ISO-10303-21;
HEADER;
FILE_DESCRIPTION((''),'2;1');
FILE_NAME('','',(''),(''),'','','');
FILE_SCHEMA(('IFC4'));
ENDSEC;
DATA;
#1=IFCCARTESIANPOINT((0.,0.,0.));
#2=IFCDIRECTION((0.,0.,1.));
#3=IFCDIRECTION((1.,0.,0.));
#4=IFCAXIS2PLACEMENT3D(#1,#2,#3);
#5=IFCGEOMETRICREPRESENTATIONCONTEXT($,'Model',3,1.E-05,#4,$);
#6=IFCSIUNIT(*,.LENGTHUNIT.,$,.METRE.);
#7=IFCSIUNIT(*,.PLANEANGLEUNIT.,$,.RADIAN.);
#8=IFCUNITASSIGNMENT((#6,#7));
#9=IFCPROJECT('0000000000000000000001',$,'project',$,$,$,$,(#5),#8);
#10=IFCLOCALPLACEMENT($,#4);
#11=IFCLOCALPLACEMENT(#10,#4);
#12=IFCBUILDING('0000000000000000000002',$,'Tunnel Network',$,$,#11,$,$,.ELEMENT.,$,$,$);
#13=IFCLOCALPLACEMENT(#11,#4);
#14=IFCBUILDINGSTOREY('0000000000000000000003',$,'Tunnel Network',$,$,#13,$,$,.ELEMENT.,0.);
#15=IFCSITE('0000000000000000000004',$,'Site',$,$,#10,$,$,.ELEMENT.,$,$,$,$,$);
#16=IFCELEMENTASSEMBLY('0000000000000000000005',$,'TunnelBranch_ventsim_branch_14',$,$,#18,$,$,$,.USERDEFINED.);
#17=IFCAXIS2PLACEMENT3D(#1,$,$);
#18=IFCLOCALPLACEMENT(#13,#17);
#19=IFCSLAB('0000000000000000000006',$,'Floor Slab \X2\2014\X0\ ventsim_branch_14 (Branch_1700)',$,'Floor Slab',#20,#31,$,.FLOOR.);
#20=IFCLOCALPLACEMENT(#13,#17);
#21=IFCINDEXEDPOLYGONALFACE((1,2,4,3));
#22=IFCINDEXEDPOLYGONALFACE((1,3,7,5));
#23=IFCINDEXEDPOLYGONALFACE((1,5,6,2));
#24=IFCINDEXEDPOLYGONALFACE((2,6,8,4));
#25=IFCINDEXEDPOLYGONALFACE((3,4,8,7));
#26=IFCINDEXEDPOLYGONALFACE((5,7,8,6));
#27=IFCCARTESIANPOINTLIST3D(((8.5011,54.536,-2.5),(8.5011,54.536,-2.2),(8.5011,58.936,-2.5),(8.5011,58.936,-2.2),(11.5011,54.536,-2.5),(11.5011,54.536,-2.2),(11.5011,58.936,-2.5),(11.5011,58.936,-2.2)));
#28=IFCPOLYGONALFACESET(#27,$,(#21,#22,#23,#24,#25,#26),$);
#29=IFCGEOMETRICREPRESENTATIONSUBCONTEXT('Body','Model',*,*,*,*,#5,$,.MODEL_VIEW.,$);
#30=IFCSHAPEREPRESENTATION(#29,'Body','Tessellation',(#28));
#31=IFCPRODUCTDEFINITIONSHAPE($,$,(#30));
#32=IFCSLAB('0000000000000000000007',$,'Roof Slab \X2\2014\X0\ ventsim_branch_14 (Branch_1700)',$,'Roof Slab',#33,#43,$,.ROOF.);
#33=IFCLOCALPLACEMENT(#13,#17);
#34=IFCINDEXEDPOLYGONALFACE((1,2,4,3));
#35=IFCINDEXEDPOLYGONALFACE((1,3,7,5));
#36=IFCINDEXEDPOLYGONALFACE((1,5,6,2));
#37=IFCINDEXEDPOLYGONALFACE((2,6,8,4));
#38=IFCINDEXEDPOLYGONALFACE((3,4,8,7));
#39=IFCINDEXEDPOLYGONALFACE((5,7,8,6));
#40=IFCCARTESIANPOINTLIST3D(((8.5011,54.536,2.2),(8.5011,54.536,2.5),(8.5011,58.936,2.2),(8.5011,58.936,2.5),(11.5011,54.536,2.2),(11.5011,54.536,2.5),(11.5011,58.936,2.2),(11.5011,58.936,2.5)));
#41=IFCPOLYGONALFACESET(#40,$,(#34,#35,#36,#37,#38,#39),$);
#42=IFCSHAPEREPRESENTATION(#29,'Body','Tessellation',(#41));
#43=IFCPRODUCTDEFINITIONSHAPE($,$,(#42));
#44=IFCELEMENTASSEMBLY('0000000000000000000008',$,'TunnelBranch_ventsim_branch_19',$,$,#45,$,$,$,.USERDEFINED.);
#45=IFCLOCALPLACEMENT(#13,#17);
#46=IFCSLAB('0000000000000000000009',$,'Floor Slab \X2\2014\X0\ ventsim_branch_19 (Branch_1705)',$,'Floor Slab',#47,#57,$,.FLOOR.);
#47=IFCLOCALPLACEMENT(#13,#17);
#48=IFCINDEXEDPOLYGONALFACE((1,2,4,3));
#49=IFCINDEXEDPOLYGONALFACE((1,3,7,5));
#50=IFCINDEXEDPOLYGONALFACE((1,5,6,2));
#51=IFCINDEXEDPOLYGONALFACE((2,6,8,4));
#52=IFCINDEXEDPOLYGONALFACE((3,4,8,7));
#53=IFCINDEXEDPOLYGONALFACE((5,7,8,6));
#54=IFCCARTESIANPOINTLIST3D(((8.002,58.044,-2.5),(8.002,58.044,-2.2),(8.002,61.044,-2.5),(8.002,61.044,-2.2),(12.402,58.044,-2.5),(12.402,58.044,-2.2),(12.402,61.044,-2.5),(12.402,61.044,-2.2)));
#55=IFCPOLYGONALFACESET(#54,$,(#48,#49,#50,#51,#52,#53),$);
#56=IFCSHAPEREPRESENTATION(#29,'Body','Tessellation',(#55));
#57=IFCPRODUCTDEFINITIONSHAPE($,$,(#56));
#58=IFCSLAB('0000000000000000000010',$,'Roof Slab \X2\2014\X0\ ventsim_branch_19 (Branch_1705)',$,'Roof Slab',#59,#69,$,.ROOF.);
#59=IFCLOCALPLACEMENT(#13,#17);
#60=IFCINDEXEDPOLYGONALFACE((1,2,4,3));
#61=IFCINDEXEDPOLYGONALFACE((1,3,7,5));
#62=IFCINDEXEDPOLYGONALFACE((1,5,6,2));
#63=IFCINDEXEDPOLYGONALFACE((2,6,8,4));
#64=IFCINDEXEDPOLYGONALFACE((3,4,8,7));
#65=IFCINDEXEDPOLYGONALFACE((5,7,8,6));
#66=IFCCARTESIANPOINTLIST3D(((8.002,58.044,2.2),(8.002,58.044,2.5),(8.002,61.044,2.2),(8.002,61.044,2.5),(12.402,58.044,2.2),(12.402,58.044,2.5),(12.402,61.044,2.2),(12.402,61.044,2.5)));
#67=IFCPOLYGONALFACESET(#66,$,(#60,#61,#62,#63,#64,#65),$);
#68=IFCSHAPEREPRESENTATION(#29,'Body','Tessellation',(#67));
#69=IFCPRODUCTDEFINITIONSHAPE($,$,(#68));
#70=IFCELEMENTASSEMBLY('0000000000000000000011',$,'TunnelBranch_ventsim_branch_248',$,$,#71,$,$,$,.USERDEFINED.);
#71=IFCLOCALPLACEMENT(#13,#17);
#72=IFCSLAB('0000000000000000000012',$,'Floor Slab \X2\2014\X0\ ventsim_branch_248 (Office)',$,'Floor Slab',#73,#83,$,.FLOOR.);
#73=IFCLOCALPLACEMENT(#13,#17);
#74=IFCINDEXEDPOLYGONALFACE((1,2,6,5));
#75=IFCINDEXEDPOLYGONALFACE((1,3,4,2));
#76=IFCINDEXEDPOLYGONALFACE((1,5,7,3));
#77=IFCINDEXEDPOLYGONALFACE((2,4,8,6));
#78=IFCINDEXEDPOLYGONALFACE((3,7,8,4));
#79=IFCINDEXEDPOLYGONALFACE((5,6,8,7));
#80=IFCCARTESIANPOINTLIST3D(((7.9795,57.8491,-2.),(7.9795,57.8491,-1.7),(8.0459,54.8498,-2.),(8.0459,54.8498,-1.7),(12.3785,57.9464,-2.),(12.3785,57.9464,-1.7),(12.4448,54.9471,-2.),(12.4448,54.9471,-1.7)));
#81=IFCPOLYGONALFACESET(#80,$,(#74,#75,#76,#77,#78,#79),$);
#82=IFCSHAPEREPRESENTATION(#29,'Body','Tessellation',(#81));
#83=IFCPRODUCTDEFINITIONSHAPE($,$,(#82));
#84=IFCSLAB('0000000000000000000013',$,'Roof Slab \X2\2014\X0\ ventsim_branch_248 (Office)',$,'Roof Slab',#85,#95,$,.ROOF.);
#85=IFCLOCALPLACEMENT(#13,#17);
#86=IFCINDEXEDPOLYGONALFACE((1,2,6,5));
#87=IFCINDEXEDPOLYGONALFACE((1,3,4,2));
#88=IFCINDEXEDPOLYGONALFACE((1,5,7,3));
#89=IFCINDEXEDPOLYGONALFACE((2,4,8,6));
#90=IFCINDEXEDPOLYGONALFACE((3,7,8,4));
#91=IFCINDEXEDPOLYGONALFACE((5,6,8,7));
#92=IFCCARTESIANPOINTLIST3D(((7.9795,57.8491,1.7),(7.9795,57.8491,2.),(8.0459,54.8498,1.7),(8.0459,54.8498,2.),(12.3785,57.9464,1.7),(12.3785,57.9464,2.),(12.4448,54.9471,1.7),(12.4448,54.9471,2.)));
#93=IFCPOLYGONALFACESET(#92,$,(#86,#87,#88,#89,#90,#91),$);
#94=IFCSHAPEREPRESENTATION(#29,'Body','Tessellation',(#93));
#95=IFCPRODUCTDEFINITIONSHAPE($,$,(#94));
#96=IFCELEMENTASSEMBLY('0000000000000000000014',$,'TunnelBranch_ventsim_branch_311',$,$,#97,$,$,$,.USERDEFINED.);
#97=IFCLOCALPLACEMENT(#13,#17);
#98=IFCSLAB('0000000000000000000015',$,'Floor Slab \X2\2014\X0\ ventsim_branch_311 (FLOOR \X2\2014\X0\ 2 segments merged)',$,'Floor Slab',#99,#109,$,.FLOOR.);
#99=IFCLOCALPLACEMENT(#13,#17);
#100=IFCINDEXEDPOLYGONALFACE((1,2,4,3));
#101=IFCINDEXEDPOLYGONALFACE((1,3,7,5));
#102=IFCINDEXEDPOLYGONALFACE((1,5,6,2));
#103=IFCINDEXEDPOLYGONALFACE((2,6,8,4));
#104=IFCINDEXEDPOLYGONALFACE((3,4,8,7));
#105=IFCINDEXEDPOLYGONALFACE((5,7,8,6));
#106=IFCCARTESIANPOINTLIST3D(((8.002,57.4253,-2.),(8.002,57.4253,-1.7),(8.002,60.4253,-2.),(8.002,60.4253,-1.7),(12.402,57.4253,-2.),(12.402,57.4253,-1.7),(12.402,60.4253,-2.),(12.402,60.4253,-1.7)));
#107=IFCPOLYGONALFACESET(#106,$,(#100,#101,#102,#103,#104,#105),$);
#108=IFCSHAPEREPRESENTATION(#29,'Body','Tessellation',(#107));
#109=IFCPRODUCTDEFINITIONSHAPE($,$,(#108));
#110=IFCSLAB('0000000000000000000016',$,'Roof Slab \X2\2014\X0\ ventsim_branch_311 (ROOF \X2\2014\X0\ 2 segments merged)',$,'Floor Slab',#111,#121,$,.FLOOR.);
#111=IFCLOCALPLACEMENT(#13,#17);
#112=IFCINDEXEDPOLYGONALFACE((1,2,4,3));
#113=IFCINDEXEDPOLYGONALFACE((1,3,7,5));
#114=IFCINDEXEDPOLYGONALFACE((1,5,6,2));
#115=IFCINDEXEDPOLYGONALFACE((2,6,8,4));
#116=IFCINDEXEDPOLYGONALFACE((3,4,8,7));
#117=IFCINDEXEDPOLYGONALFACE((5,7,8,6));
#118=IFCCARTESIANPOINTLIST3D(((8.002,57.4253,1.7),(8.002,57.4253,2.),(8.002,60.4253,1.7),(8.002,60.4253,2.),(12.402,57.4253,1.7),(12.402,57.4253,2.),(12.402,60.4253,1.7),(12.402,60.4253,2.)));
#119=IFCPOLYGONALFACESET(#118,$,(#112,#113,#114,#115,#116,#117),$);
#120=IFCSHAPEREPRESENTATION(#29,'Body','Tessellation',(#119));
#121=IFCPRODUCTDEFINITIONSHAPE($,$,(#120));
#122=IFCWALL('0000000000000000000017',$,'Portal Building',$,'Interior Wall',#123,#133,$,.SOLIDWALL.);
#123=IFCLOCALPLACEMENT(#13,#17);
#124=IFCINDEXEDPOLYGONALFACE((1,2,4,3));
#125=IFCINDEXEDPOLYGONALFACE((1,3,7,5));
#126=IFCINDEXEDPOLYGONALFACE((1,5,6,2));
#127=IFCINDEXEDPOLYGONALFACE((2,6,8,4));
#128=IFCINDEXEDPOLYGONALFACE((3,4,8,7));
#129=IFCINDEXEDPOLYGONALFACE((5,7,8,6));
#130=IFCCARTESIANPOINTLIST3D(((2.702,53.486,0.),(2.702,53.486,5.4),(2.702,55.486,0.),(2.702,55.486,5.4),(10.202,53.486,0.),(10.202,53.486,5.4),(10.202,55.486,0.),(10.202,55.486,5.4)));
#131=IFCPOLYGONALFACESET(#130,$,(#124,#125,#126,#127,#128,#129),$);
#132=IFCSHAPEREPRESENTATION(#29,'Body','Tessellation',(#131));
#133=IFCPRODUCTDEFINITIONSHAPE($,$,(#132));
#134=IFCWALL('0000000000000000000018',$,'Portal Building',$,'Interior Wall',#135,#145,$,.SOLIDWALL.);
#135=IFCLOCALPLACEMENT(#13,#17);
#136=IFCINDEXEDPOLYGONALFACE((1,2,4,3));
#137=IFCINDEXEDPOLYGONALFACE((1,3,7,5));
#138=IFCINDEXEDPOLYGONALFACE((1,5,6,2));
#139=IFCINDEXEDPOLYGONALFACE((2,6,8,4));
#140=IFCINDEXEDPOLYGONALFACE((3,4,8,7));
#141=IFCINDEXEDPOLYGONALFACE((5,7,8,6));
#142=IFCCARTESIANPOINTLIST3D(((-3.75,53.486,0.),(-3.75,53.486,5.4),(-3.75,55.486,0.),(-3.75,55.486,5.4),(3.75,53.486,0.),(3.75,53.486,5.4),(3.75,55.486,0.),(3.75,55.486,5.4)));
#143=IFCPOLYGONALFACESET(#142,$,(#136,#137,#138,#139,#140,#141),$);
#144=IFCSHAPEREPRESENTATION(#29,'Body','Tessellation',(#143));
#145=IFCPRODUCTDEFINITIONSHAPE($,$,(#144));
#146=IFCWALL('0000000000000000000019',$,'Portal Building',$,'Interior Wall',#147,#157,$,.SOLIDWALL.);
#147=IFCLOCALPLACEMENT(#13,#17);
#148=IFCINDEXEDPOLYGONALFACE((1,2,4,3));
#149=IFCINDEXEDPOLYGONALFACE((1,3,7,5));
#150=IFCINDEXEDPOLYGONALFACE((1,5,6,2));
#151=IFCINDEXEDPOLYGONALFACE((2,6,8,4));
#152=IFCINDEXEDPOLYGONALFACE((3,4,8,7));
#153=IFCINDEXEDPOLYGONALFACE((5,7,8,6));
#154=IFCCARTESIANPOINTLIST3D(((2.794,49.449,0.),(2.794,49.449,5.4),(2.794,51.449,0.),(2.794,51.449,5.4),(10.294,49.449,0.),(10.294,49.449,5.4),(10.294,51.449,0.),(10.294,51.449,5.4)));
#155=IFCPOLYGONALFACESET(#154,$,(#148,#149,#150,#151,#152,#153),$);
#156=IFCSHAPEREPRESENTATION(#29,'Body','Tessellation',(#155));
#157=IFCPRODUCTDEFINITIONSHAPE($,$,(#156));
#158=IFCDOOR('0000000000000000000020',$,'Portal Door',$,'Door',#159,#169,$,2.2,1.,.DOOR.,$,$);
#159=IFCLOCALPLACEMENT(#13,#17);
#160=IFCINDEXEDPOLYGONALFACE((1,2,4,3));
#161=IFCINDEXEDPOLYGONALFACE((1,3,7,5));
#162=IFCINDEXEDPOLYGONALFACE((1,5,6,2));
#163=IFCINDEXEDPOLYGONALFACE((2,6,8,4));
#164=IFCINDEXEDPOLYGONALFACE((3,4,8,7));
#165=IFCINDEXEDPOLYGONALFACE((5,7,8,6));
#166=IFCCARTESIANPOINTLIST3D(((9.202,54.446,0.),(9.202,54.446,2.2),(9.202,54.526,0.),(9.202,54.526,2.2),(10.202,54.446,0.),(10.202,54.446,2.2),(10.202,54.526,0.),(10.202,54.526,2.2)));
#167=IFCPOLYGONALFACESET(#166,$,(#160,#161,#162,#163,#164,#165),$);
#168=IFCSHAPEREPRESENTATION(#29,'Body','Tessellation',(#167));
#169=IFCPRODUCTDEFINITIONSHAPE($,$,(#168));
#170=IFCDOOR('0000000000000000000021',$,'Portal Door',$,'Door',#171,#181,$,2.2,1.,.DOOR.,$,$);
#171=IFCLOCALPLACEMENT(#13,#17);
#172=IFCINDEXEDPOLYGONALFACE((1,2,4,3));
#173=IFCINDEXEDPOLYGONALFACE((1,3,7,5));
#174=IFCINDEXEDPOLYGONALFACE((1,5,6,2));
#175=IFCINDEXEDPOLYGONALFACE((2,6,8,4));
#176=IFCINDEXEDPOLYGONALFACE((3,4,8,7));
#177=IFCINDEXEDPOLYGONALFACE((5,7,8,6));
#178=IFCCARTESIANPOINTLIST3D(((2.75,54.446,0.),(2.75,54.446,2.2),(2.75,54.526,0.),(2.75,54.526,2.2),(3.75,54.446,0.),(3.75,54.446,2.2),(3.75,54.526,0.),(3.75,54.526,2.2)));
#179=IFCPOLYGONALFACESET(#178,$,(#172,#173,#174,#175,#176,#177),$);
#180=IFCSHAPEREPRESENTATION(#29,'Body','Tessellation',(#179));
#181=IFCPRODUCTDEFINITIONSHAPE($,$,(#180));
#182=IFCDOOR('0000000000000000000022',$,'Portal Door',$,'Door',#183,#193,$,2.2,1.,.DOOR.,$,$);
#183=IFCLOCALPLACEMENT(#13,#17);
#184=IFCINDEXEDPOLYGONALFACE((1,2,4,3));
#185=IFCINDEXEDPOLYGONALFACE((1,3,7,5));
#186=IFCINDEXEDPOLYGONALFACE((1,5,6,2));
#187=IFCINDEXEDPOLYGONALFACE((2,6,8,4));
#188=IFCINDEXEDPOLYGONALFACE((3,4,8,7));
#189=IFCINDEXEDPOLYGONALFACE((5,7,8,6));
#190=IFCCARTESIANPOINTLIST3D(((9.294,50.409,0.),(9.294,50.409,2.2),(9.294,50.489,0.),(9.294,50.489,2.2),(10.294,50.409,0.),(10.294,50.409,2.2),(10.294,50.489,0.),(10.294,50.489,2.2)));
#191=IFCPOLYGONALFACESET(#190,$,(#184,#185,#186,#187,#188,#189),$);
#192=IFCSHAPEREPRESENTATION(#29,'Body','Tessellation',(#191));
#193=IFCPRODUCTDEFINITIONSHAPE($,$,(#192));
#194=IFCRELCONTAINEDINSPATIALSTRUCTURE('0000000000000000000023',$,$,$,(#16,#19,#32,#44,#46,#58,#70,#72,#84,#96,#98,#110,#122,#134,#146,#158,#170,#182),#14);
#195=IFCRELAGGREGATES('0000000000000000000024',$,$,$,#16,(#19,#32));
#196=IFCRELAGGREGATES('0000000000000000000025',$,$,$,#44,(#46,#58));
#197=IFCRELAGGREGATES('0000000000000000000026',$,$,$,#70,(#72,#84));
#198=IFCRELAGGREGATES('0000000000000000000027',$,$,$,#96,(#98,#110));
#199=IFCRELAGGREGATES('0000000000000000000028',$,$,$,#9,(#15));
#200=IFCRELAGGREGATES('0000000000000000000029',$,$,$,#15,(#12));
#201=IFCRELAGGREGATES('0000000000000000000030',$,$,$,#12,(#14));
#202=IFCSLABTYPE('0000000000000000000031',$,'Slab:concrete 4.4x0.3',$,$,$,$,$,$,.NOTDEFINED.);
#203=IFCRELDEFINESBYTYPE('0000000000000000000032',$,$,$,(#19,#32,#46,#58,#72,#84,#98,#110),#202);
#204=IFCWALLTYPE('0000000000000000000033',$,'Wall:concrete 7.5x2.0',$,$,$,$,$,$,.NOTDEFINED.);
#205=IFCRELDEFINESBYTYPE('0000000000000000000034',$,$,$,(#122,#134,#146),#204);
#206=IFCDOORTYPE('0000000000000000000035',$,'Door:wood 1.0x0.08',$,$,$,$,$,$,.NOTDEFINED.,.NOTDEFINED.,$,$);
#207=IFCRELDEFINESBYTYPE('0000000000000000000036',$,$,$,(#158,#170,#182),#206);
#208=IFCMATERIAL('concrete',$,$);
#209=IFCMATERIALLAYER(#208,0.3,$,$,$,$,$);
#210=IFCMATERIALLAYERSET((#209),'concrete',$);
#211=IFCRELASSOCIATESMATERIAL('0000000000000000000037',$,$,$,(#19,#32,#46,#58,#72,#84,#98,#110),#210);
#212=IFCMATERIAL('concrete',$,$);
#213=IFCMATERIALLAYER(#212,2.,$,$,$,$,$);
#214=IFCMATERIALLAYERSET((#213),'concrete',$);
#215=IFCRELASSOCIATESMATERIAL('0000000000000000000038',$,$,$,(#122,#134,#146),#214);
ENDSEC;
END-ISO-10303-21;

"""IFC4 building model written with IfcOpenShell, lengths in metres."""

from ifc_helpers import new_model, si_unit, frame, origin_with_axes, origin_2d_with_axis, place, context, subcontext, project, spatial, rectangle, extrude, material, layer, layer_set, layer_usage, type_object, element, aggregate, save


model = new_model("IFC4")

# Units and contexts
model_context = context("Model", 3, precision=1e-05, world=origin_with_axes())
body_context = subcontext(model_context, "Body", "Model", "MODEL_VIEW")
ifc_project = project(units=[si_unit("LENGTHUNIT", "METRE"), si_unit("PLANEANGLEUNIT", "RADIAN")], contexts=[model_context])

# Site, building, storey
site_placement = place(None, origin_with_axes())
site = spatial("IfcSite", under=ifc_project, at=site_placement, Name="Site", CompositionType="ELEMENT")
building_placement = place(site_placement, origin_with_axes())
building = spatial("IfcBuilding", under=site, at=building_placement, Name="Tunnel Network", CompositionType="ELEMENT")
storey_placement = place(building_placement, origin_with_axes())
storey = spatial("IfcBuildingStorey", under=building, at=storey_placement, Name="Tunnel Network", CompositionType="ELEMENT", Elevation=0.0)

# Element assemblies, slabs
assembly_1_placement = place(storey_placement, frame((9.3955, 54.386, 0.0), z_axis=(-1.0, 0.0, 0.0), x_axis=(0.0, 1.0, 0.0)))
assembly_1 = element("IfcElementAssembly", 1, at=assembly_1_placement, inside=storey, Name="TunnelBranch_ventsim_branch_14", PredefinedType="USERDEFINED")
ifc_material_1 = material(Name="concrete")
ifc_layer_1 = layer(ifc_material_1, 0.3)
ifc_layer_set_1 = layer_set([ifc_layer_1], Name="concrete")
ifc_layer_usage_1 = layer_usage(ifc_layer_set_1, "AXIS3", "POSITIVE", 0.0)
slab_type = type_object("IfcSlabType", Name="Slab:concrete 4.4x0.3")
slab_1_placement = place(storey_placement, frame((11.5011, 56.736, -2.35), z_axis=(-1.0, 0.0, 0.0), x_axis=(0.0, 1.0, 0.0)))
slab_1 = element("IfcSlab", 2, at=slab_1_placement, inside=storey, type_object=slab_type, material=ifc_layer_usage_1, Name="Floor Slab — ventsim_branch_14 (Branch_1700)", ObjectType="Floor Slab", PredefinedType="FLOOR", context=body_context, shape_type="SweptSolid", body=[
    extrude(rectangle(XDim=4.4, YDim=0.3, at=origin_2d_with_axis()), origin_with_axes(), (0.0, 0.0, 1.0), 3.0),
])
ifc_layer_usage_2 = layer_usage(ifc_layer_set_1, "AXIS3", "POSITIVE", 0.0)
slab_2_placement = place(storey_placement, frame((11.5011, 56.736, 2.35), z_axis=(-1.0, 0.0, 0.0), x_axis=(0.0, 1.0, 0.0)))
slab_2 = element("IfcSlab", 3, at=slab_2_placement, inside=storey, type_object=slab_type, material=ifc_layer_usage_2, Name="Roof Slab — ventsim_branch_14 (Branch_1700)", ObjectType="Roof Slab", PredefinedType="ROOF", context=body_context, shape_type="SweptSolid", body=[
    extrude(rectangle(XDim=4.4, YDim=0.3, at=origin_2d_with_axis()), origin_with_axes(), (0.0, 0.0, 1.0), 3.0),
])
assembly_2_placement = place(storey_placement, frame((12.552, 61.044, 0.0), z_axis=(0.0, -1.0, 0.0), x_axis=(-1.0, 0.0, 0.0)))
assembly_2 = element("IfcElementAssembly", 4, at=assembly_2_placement, inside=storey, Name="TunnelBranch_ventsim_branch_19", PredefinedType="USERDEFINED")
ifc_layer_usage_3 = layer_usage(ifc_layer_set_1, "AXIS3", "POSITIVE", 0.0)
slab_3_placement = place(storey_placement, frame((10.202, 61.044, -2.35), z_axis=(0.0, -1.0, 0.0), x_axis=(-1.0, 0.0, 0.0)))
slab_3 = element("IfcSlab", 5, at=slab_3_placement, inside=storey, type_object=slab_type, material=ifc_layer_usage_3, Name="Floor Slab — ventsim_branch_19 (Branch_1705)", ObjectType="Floor Slab", PredefinedType="FLOOR", context=body_context, shape_type="SweptSolid", body=[
    extrude(rectangle(XDim=4.4, YDim=0.3, at=origin_2d_with_axis()), origin_with_axes(), (0.0, 0.0, 1.0), 3.0),
])
ifc_layer_usage_4 = layer_usage(ifc_layer_set_1, "AXIS3", "POSITIVE", 0.0)
slab_4_placement = place(storey_placement, frame((10.202, 61.044, 2.35), z_axis=(0.0, -1.0, 0.0), x_axis=(-1.0, 0.0, 0.0)))
slab_4 = element("IfcSlab", 6, at=slab_4_placement, inside=storey, type_object=slab_type, material=ifc_layer_usage_4, Name="Roof Slab — ventsim_branch_19 (Branch_1705)", ObjectType="Roof Slab", PredefinedType="ROOF", context=body_context, shape_type="SweptSolid", body=[
    extrude(rectangle(XDim=4.4, YDim=0.3, at=origin_2d_with_axis()), origin_with_axes(), (0.0, 0.0, 1.0), 3.0),
])
assembly_3_placement = place(storey_placement, frame((12.4981, 59.3193, 0.0), z_axis=(0.022115, -0.999755, 0.0), x_axis=(-0.999755, -0.022115, 0.0)))
assembly_3 = element("IfcElementAssembly", 7, at=assembly_3_placement, inside=storey, Name="TunnelBranch_ventsim_branch_248", PredefinedType="USERDEFINED")
ifc_layer_usage_5 = layer_usage(ifc_layer_set_1, "AXIS3", "POSITIVE", 0.0)
slab_5_placement = place(storey_placement, frame((10.179, 57.8977, -1.85), z_axis=(0.022115, -0.999755, 0.0), x_axis=(-0.999755, -0.022115, 0.0)))
slab_5 = element("IfcSlab", 8, at=slab_5_placement, inside=storey, type_object=slab_type, material=ifc_layer_usage_5, Name="Floor Slab — ventsim_branch_248 (Office)", ObjectType="Floor Slab", PredefinedType="FLOOR", context=body_context, shape_type="SweptSolid", body=[
    extrude(rectangle(XDim=4.4, YDim=0.3, at=origin_2d_with_axis()), origin_with_axes(), (0.0, 0.0, 1.0), 3.0),
])
ifc_layer_usage_6 = layer_usage(ifc_layer_set_1, "AXIS3", "POSITIVE", 0.0)
slab_6_placement = place(storey_placement, frame((10.179, 57.8977, 1.85), z_axis=(0.022115, -0.999755, 0.0), x_axis=(-0.999755, -0.022115, 0.0)))
slab_6 = element("IfcSlab", 9, at=slab_6_placement, inside=storey, type_object=slab_type, material=ifc_layer_usage_6, Name="Roof Slab — ventsim_branch_248 (Office)", ObjectType="Roof Slab", PredefinedType="ROOF", context=body_context, shape_type="SweptSolid", body=[
    extrude(rectangle(XDim=4.4, YDim=0.3, at=origin_2d_with_axis()), origin_with_axes(), (0.0, 0.0, 1.0), 3.0),
])
assembly_4_placement = place(storey_placement, frame((10.202, 56.2907, 0.0), z_axis=(0.0, 1.0, 0.0), x_axis=(1.0, 0.0, 0.0)))
assembly_4 = element("IfcElementAssembly", 10, at=assembly_4_placement, inside=storey, Name="TunnelBranch_ventsim_branch_311", PredefinedType="USERDEFINED")
ifc_layer_usage_7 = layer_usage(ifc_layer_set_1, "AXIS3", "POSITIVE", 0.0)
slab_7_placement = place(storey_placement, frame((10.202, 57.4253, -1.85), z_axis=(0.0, 1.0, 0.0), x_axis=(1.0, 0.0, 0.0)))
slab_7 = element("IfcSlab", 11, at=slab_7_placement, inside=storey, type_object=slab_type, material=ifc_layer_usage_7, Name="Floor Slab — ventsim_branch_311 (FLOOR — 2 segments merged)", ObjectType="Floor Slab", PredefinedType="FLOOR", context=body_context, shape_type="SweptSolid", body=[
    extrude(rectangle(XDim=4.4, YDim=0.3, at=origin_2d_with_axis()), origin_with_axes(), (0.0, 0.0, 1.0), 3.0),
])
ifc_layer_usage_8 = layer_usage(ifc_layer_set_1, "AXIS3", "POSITIVE", 0.0)
slab_8_placement = place(storey_placement, frame((10.202, 57.4253, 1.85), z_axis=(0.0, 1.0, 0.0), x_axis=(1.0, 0.0, 0.0)))
slab_8 = element("IfcSlab", 12, at=slab_8_placement, inside=storey, type_object=slab_type, material=ifc_layer_usage_8, Name="Roof Slab — ventsim_branch_311 (ROOF — 2 segments merged)", ObjectType="Floor Slab", PredefinedType="FLOOR", context=body_context, shape_type="SweptSolid", body=[
    extrude(rectangle(XDim=4.4, YDim=0.3, at=origin_2d_with_axis()), origin_with_axes(), (0.0, 0.0, 1.0), 3.0),
])

# Walls
ifc_material_2 = material(Name="concrete")
ifc_layer_2 = layer(ifc_material_2, 2.0)
ifc_layer_set_2 = layer_set([ifc_layer_2], Name="concrete")
ifc_layer_usage_9 = layer_usage(ifc_layer_set_2, "AXIS2", "POSITIVE", 0.0)
wall_type_1 = type_object("IfcWallType", Name="Wall:concrete 7.5x2.0")
wall_1_placement = place(storey_placement, frame((6.452, 54.486, 0.0), z_axis=(0.0, 0.0, 1.0), x_axis=(1.0, 0.0, 0.0)))
element("IfcWall", 13, at=wall_1_placement, inside=storey, type_object=wall_type_1, material=ifc_layer_usage_9, Name="Portal Building", ObjectType="Interior Wall", PredefinedType="SOLIDWALL", context=body_context, shape_type="SweptSolid", body=[
    extrude(rectangle(XDim=7.5, YDim=2.0, at=origin_2d_with_axis()), origin_with_axes(), (0.0, 0.0, 1.0), 5.4),
])
ifc_layer_usage_10 = layer_usage(ifc_layer_set_2, "AXIS2", "POSITIVE", 0.0)
wall_2_placement = place(storey_placement, frame((0.0, 54.486, 0.0), z_axis=(0.0, 0.0, 1.0), x_axis=(1.0, 0.0, 0.0)))
element("IfcWall", 14, at=wall_2_placement, inside=storey, type_object=wall_type_1, material=ifc_layer_usage_10, Name="Portal Building", ObjectType="Interior Wall", PredefinedType="SOLIDWALL", context=body_context, shape_type="SweptSolid", body=[
    extrude(rectangle(XDim=7.5, YDim=2.0, at=origin_2d_with_axis()), origin_with_axes(), (0.0, 0.0, 1.0), 5.4),
])
ifc_layer_usage_11 = layer_usage(ifc_layer_set_2, "AXIS2", "POSITIVE", 0.0)
wall_3_placement = place(storey_placement, frame((6.544, 50.449, 0.0), z_axis=(0.0, 0.0, 1.0), x_axis=(1.0, 0.0, 0.0)))
element("IfcWall", 15, at=wall_3_placement, inside=storey, type_object=wall_type_1, material=ifc_layer_usage_11, Name="Portal Building", ObjectType="Interior Wall", PredefinedType="SOLIDWALL", context=body_context, shape_type="SweptSolid", body=[
    extrude(rectangle(XDim=7.5, YDim=2.0, at=origin_2d_with_axis()), origin_with_axes(), (0.0, 0.0, 1.0), 5.4),
])

# Doors
door_type = type_object("IfcDoorType", Name="Door:wood 1.0x0.08")
for number, where, z_axis, x_axis, name in (
    (16, (9.702, 54.486, 0.0), (0.0, 0.0, 1.0), (1.0, 0.0, 0.0), "Portal Door"),
    (17, (3.25, 54.486, 0.0), (0.0, 0.0, 1.0), (1.0, 0.0, 0.0), "Portal Door"),
    (18, (9.794, 50.449, 0.0), (0.0, 0.0, 1.0), (1.0, 0.0, 0.0), "Portal Door"),
):
    element("IfcDoor", number, at=place(storey_placement, frame(where, z_axis=z_axis, x_axis=x_axis)), inside=storey, type_object=door_type, Name=name, ObjectType="Door", OverallHeight=2.2, OverallWidth=1.0, PredefinedType="DOOR", context=body_context, shape_type="SweptSolid", body=[
        extrude(rectangle(XDim=1.0, YDim=0.08, at=origin_2d_with_axis()), origin_with_axes(), (0.0, 0.0, 1.0), 2.2),
    ])

aggregate(assembly_1, [slab_1, slab_2])
aggregate(assembly_2, [slab_3, slab_4])
aggregate(assembly_3, [slab_5, slab_6])
aggregate(assembly_4, [slab_7, slab_8])

save(model, "model.ifc")
